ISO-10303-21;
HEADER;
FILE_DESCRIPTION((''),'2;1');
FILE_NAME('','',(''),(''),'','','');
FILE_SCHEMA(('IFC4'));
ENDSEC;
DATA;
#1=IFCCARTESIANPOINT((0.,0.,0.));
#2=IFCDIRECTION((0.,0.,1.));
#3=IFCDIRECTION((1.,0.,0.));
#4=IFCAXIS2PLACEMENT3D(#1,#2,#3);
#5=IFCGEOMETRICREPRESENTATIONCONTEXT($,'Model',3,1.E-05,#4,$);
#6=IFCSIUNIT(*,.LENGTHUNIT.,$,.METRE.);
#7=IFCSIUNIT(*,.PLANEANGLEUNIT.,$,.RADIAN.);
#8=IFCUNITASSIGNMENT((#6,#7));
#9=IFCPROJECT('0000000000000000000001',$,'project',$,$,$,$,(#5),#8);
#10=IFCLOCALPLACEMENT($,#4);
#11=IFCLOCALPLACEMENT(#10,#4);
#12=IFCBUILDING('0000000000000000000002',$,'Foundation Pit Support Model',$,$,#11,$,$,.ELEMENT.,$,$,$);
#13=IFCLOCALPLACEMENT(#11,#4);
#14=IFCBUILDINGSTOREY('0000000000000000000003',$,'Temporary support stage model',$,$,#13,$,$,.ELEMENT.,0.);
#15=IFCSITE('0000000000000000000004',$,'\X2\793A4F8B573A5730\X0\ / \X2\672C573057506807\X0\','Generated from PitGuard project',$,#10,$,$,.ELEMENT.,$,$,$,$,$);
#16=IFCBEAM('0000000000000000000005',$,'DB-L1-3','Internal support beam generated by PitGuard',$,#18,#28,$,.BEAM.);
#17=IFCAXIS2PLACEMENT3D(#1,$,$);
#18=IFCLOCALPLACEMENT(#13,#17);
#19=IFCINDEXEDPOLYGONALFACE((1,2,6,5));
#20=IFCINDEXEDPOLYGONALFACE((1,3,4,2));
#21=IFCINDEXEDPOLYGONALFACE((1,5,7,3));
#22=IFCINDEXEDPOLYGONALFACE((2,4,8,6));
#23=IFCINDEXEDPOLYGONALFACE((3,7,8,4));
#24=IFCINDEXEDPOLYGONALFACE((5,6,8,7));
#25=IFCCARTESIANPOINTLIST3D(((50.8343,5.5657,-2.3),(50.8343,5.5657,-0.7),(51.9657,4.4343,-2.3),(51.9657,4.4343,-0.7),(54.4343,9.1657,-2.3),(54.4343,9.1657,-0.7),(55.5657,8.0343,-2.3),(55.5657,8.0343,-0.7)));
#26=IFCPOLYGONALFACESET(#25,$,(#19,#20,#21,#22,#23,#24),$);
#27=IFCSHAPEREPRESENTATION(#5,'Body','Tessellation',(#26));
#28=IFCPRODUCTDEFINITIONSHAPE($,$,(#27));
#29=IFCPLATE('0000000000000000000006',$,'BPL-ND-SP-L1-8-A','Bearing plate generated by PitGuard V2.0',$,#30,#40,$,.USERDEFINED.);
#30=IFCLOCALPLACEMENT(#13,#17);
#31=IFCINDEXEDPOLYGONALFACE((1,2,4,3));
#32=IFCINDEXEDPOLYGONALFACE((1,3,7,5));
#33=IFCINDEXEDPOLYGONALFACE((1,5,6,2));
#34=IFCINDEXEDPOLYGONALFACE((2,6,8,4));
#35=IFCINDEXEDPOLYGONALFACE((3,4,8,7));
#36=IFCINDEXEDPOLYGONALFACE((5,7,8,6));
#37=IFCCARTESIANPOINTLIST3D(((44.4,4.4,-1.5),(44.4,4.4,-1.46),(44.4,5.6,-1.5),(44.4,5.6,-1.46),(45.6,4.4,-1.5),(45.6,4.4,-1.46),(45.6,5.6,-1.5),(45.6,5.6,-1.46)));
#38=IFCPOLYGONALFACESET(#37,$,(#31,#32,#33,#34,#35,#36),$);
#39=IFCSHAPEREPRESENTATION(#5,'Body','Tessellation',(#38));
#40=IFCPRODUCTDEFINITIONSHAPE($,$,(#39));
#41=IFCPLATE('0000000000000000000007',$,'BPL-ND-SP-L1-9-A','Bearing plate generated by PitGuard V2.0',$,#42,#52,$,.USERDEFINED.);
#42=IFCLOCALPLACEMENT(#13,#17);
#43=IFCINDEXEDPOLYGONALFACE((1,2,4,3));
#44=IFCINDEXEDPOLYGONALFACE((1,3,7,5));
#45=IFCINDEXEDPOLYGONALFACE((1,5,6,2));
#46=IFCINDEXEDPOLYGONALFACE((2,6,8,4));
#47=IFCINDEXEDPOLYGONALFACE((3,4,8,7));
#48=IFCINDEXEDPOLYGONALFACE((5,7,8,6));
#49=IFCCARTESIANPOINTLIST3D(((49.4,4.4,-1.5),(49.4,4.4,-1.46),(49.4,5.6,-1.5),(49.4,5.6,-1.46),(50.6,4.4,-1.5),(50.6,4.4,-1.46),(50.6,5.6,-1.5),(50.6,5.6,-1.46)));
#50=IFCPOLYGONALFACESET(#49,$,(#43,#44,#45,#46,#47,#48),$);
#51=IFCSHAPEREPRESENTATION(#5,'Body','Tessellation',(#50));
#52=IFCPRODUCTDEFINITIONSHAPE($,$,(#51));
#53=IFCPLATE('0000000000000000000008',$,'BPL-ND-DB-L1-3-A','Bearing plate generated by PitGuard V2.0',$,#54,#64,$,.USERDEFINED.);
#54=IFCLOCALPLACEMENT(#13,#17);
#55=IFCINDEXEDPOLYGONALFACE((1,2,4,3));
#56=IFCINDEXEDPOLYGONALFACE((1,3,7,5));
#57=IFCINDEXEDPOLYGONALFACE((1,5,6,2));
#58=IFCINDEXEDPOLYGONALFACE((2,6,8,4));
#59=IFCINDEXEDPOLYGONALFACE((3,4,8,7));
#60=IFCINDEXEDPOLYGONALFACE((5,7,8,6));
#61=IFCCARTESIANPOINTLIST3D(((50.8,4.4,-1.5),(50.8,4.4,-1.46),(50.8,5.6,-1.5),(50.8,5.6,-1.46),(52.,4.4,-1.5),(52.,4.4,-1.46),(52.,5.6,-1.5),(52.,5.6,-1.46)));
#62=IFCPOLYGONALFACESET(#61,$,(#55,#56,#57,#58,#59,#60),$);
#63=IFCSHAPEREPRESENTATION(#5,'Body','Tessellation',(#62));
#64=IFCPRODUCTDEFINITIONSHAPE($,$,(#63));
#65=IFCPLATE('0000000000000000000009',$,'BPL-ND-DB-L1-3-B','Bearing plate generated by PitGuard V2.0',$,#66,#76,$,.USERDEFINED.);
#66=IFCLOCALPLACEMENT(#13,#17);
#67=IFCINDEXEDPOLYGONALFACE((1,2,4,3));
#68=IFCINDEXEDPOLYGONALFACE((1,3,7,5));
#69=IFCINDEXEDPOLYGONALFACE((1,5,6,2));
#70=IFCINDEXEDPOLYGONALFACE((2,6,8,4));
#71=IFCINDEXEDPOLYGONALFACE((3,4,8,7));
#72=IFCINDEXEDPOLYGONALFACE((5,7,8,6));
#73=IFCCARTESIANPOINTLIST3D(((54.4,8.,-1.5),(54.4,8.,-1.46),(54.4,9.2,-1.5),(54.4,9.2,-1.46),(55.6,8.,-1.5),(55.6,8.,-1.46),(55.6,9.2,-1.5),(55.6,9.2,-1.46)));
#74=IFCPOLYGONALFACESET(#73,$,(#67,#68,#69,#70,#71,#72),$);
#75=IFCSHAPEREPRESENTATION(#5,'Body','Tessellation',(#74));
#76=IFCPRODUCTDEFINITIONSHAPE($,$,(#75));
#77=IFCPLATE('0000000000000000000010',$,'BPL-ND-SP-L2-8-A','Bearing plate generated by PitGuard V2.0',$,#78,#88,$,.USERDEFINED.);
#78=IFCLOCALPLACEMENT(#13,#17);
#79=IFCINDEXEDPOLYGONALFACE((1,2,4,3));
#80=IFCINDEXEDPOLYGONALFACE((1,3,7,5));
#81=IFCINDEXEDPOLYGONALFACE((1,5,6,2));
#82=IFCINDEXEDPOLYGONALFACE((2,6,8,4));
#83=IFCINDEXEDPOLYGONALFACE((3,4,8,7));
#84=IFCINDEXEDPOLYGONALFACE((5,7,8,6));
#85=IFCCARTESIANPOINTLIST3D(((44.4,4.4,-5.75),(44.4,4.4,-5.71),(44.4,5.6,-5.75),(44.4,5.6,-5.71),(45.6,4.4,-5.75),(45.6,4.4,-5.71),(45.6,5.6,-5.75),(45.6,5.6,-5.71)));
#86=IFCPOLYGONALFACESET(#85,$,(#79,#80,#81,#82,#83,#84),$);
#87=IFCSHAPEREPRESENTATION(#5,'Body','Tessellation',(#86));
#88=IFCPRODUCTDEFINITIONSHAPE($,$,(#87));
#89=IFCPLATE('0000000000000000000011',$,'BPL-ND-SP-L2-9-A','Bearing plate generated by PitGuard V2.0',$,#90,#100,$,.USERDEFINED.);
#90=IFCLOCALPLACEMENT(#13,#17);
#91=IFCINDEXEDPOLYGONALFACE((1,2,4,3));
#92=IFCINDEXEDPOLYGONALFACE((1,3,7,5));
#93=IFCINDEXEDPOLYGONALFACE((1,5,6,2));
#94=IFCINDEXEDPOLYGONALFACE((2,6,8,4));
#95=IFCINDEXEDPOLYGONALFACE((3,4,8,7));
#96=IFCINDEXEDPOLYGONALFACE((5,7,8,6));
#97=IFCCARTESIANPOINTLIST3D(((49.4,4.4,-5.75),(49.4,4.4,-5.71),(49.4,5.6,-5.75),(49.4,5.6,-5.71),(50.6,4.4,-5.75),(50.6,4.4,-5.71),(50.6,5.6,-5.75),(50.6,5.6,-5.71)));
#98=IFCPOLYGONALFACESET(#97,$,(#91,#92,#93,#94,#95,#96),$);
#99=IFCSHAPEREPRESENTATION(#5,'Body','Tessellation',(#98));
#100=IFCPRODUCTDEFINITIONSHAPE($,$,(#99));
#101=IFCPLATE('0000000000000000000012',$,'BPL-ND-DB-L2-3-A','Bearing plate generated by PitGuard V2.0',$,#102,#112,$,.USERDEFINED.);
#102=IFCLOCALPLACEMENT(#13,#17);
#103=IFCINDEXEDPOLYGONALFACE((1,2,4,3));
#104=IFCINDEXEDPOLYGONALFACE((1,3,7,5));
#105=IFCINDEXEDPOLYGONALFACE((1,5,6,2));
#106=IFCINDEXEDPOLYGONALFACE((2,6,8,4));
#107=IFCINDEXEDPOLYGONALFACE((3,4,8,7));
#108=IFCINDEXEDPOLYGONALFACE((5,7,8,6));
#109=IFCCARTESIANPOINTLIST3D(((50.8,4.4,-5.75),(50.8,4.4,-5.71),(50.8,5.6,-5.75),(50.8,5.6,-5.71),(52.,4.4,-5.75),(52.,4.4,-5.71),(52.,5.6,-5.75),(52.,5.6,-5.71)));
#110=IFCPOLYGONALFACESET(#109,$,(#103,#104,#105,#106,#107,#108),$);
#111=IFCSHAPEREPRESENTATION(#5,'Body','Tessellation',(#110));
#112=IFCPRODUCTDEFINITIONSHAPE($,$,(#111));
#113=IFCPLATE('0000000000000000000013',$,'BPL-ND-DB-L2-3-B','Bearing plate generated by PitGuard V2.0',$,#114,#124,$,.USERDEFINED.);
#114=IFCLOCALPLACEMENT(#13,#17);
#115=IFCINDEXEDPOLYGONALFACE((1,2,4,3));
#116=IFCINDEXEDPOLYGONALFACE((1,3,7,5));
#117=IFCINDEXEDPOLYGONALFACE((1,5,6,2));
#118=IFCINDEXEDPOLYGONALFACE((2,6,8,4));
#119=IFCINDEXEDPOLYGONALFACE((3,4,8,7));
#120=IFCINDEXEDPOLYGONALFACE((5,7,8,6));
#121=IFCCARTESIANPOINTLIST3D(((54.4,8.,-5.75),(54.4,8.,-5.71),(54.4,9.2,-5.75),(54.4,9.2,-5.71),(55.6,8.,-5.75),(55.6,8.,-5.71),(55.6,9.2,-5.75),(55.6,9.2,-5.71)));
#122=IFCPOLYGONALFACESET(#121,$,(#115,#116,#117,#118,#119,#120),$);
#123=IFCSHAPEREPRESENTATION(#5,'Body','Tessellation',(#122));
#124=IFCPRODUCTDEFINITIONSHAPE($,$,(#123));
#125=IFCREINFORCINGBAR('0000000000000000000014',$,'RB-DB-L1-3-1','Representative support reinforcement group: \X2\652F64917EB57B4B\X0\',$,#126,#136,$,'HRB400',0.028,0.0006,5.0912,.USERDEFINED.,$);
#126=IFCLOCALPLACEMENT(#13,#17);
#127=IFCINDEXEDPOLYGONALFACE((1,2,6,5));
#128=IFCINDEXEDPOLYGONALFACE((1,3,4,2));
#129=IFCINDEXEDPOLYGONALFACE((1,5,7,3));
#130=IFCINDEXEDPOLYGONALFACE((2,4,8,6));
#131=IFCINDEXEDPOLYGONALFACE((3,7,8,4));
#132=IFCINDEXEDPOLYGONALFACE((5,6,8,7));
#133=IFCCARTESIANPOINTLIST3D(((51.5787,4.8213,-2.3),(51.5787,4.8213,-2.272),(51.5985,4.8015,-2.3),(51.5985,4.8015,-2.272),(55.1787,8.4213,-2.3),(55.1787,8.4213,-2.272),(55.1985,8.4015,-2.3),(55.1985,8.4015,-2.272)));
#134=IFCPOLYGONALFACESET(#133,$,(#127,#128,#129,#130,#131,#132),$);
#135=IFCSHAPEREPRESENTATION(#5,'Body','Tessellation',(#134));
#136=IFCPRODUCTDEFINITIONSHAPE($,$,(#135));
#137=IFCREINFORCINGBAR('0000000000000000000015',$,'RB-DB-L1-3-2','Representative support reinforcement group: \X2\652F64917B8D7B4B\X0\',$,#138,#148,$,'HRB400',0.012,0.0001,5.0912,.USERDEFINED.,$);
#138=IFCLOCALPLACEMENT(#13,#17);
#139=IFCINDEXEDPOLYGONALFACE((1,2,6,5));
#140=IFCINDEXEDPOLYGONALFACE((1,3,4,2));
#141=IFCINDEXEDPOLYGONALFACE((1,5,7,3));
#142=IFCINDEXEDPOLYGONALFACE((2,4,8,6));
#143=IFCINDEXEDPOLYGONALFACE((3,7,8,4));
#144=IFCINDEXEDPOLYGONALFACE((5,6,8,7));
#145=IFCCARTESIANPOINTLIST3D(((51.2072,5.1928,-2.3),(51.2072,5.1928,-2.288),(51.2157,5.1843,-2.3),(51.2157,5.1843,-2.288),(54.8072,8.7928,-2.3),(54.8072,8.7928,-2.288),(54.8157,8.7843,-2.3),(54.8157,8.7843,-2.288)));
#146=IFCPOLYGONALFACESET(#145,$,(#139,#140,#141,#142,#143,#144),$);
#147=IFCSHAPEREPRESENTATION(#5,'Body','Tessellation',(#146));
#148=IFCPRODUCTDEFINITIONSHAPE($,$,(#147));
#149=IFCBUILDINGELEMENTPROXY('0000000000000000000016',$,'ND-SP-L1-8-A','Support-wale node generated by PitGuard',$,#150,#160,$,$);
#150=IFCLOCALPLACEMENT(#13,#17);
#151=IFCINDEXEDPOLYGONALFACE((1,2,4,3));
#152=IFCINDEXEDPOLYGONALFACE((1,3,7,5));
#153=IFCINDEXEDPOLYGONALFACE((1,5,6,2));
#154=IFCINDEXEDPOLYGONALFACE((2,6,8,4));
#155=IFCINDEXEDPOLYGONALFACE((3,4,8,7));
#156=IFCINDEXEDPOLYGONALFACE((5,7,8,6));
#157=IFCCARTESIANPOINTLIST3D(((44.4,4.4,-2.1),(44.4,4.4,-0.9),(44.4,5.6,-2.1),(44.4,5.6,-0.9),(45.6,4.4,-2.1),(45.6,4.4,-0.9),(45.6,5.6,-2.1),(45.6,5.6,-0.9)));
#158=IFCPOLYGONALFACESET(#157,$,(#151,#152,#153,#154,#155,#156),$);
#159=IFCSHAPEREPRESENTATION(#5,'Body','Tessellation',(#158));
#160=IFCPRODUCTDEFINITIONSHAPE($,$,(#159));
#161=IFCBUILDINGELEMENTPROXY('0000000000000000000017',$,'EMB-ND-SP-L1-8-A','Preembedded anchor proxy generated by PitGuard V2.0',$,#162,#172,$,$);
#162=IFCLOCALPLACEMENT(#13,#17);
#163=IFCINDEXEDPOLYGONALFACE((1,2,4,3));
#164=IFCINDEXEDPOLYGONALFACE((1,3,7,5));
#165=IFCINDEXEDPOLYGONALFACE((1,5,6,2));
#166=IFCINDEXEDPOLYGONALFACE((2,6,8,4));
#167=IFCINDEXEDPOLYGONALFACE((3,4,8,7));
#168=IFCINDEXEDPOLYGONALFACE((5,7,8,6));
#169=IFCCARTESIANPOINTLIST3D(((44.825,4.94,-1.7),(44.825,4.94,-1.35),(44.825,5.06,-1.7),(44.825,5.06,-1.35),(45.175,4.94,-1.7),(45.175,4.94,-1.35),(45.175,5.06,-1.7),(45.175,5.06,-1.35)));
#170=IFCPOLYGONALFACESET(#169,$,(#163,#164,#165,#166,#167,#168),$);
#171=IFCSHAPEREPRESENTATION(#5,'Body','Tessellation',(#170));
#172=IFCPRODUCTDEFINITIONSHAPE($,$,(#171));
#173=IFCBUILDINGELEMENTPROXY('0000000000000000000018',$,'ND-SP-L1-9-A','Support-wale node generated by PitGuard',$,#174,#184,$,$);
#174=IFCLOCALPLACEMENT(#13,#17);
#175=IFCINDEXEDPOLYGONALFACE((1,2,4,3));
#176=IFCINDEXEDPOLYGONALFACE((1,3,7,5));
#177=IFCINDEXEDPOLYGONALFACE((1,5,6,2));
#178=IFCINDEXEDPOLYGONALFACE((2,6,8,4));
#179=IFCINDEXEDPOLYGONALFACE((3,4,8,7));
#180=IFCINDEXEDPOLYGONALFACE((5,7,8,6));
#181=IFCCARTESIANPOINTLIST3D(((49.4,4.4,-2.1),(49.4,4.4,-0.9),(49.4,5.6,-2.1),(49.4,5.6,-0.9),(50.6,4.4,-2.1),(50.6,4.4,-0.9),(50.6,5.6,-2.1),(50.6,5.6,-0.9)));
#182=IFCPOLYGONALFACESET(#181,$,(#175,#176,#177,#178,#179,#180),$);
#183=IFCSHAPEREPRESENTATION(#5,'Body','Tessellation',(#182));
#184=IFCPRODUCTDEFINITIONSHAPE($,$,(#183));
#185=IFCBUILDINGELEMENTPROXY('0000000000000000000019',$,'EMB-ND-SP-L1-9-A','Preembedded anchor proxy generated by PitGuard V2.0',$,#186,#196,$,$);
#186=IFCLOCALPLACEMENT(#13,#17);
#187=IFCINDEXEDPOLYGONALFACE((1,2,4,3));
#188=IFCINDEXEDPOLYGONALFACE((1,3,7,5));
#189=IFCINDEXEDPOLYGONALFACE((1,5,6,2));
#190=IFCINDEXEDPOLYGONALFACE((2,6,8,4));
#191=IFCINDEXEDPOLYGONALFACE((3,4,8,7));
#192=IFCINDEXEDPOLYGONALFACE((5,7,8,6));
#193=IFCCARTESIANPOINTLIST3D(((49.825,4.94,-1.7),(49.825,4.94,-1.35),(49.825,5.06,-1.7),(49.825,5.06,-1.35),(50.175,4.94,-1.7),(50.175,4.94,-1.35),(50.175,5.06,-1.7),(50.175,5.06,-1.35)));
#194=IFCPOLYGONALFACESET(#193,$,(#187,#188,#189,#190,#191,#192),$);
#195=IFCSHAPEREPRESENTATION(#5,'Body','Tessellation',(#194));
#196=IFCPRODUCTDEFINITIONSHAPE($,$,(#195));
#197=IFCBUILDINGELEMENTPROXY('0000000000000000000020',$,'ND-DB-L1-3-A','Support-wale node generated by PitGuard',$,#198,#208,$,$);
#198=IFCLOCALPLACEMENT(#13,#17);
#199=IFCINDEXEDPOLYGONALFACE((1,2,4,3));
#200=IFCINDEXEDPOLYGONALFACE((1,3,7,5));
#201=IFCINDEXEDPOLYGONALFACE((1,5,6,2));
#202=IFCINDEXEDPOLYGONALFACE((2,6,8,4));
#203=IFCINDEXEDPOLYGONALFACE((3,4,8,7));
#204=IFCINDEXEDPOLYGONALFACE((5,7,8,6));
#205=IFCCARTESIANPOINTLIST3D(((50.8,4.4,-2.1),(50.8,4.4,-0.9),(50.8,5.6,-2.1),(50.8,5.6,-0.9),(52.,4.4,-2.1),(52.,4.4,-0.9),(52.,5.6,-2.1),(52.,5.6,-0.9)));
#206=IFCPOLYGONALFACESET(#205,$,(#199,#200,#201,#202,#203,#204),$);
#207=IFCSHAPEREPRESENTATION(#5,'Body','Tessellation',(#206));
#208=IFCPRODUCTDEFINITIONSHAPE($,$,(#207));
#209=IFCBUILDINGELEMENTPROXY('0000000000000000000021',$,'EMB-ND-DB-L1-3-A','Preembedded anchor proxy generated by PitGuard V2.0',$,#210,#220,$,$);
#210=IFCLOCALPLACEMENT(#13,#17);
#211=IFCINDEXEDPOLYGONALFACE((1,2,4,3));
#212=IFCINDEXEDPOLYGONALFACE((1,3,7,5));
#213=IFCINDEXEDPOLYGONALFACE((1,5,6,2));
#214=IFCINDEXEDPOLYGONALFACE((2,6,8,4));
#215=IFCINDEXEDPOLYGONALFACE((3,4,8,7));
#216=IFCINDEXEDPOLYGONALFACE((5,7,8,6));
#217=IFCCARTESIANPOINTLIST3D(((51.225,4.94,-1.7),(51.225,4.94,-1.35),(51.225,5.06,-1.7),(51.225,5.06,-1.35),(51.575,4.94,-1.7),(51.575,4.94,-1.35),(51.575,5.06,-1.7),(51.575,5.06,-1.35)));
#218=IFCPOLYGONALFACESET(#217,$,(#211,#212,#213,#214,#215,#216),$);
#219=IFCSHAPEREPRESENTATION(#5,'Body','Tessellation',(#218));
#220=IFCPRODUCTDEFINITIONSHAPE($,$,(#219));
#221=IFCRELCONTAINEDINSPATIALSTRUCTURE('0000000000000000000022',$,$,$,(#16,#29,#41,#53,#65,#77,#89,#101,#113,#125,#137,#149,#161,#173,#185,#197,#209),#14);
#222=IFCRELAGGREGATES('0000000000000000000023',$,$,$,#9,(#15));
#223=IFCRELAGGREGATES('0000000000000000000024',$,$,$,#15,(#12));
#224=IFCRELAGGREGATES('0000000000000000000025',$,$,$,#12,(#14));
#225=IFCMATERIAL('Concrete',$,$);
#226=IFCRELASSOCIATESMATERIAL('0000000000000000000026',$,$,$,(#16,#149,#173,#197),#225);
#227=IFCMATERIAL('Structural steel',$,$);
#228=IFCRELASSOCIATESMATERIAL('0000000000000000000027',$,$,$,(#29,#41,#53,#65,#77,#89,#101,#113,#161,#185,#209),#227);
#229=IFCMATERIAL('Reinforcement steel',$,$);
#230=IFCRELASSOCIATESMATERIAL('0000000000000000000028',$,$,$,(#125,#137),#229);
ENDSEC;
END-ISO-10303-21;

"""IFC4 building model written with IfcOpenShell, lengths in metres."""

from ifc_helpers import new_model, si_unit, frame, origin_with_axes, origin_2d, place, context, project, spatial, rectangle, extrude, material, element, save


model = new_model("IFC4")

# Units and contexts
model_context = context("Model", 3, precision=1e-05, world=origin_with_axes())
ifc_project = project(units=[si_unit("LENGTHUNIT", "METRE"), si_unit("PLANEANGLEUNIT", "RADIAN")], contexts=[model_context])

# Site, building, storey
site_placement = place(None, origin_with_axes())
site = spatial("IfcSite", under=ifc_project, at=site_placement, Name="示例场地 / 本地坐标", Description="Generated from PitGuard project", CompositionType="ELEMENT")
building_placement = place(site_placement, origin_with_axes())
building = spatial("IfcBuilding", under=site, at=building_placement, Name="Foundation Pit Support Model", CompositionType="ELEMENT")
storey_placement = place(building_placement, origin_with_axes())
storey = spatial("IfcBuildingStorey", under=building, at=storey_placement, Name="Temporary support stage model", CompositionType="ELEMENT", Elevation=0.0)

# Beam
ifc_material_1 = material(Name="Concrete")
beam_placement = place(storey_placement, frame((53.2, 6.8, -2.3), z_axis=(0.0, 0.0, 1.0), x_axis=(0.707107, 0.707107, 0.0)))
element("IfcBeam", 1, at=beam_placement, inside=storey, material=ifc_material_1, Name="DB-L1-3", Description="Internal support beam generated by PitGuard", PredefinedType="BEAM", context=model_context, shape_type="SweptSolid", body=[
    extrude(rectangle(XDim=5.0912, YDim=1.6, at=origin_2d()), origin_with_axes(), (0.0, 0.0, 1.0), 1.6),
])

# Plates
ifc_material_2 = material(Name="Structural steel")
for number, where, z_axis, x_axis, name in (
    (2, (45.0, 5.0, -1.5), (0.0, 0.0, 1.0), (1.0, 0.0, 0.0), "BPL-ND-SP-L1-8-A"),
    (3, (50.0, 5.0, -1.5), (0.0, 0.0, 1.0), (1.0, 0.0, 0.0), "BPL-ND-SP-L1-9-A"),
    (4, (51.4, 5.0, -1.5), (0.0, 0.0, 1.0), (1.0, 0.0, 0.0), "BPL-ND-DB-L1-3-A"),
    (5, (55.0, 8.6, -1.5), (0.0, 0.0, 1.0), (1.0, 0.0, 0.0), "BPL-ND-DB-L1-3-B"),
    (6, (45.0, 5.0, -5.75), (0.0, 0.0, 1.0), (1.0, 0.0, 0.0), "BPL-ND-SP-L2-8-A"),
    (7, (50.0, 5.0, -5.75), (0.0, 0.0, 1.0), (1.0, 0.0, 0.0), "BPL-ND-SP-L2-9-A"),
    (8, (51.4, 5.0, -5.75), (0.0, 0.0, 1.0), (1.0, 0.0, 0.0), "BPL-ND-DB-L2-3-A"),
    (9, (55.0, 8.6, -5.75), (0.0, 0.0, 1.0), (1.0, 0.0, 0.0), "BPL-ND-DB-L2-3-B"),
):
    element("IfcPlate", number, at=place(storey_placement, frame(where, z_axis=z_axis, x_axis=x_axis)), inside=storey, material=ifc_material_2, Name=name, Description="Bearing plate generated by PitGuard V2.0", PredefinedType="USERDEFINED", context=model_context, shape_type="SweptSolid", body=[
        extrude(rectangle(XDim=1.2, YDim=1.2, at=origin_2d()), origin_with_axes(), (0.0, 0.0, 1.0), 0.04),
    ])

# Reinforcing bars
ifc_material_3 = material(Name="Reinforcement steel")
reinforcing_bar_1_placement = place(storey_placement, frame((53.3886, 6.6114, -2.3), z_axis=(0.0, 0.0, 1.0), x_axis=(0.707107, 0.707107, 0.0)))
element("IfcReinforcingBar", 10, at=reinforcing_bar_1_placement, inside=storey, material=ifc_material_3, Name="RB-DB-L1-3-1", Description="Representative support reinforcement group: 支撑纵筋", SteelGrade="HRB400", BarLength=5.0912, CrossSectionArea=0.0006, NominalDiameter=0.028, PredefinedType="USERDEFINED", context=model_context, shape_type="SweptSolid", body=[
    extrude(rectangle(XDim=5.0912, YDim=0.028, at=origin_2d()), origin_with_axes(), (0.0, 0.0, 1.0), 0.028),
])
reinforcing_bar_2_placement = place(storey_placement, frame((53.0114, 6.9886, -2.3), z_axis=(0.0, 0.0, 1.0), x_axis=(0.707107, 0.707107, 0.0)))
element("IfcReinforcingBar", 11, at=reinforcing_bar_2_placement, inside=storey, material=ifc_material_3, Name="RB-DB-L1-3-2", Description="Representative support reinforcement group: 支撑箍筋", SteelGrade="HRB400", BarLength=5.0912, CrossSectionArea=0.0001, NominalDiameter=0.012, PredefinedType="USERDEFINED", context=model_context, shape_type="SweptSolid", body=[
    extrude(rectangle(XDim=5.0912, YDim=0.012, at=origin_2d()), origin_with_axes(), (0.0, 0.0, 1.0), 0.012),
])

# Building element proxies
proxy_1_placement = place(storey_placement, frame((45.0, 5.0, -2.1), z_axis=(0.0, 0.0, 1.0), x_axis=(1.0, 0.0, 0.0)))
element("IfcBuildingElementProxy", 12, at=proxy_1_placement, inside=storey, material=ifc_material_1, Name="ND-SP-L1-8-A", Description="Support-wale node generated by PitGuard", context=model_context, shape_type="SweptSolid", body=[
    extrude(rectangle(XDim=1.2, YDim=1.2, at=origin_2d()), origin_with_axes(), (0.0, 0.0, 1.0), 1.2),
])
proxy_2_placement = place(storey_placement, frame((45.0, 5.0, -1.7), z_axis=(0.0, 0.0, 1.0), x_axis=(1.0, 0.0, 0.0)))
element("IfcBuildingElementProxy", 13, at=proxy_2_placement, inside=storey, material=ifc_material_2, Name="EMB-ND-SP-L1-8-A", Description="Preembedded anchor proxy generated by PitGuard V2.0", context=model_context, shape_type="SweptSolid", body=[
    extrude(rectangle(XDim=0.35, YDim=0.12, at=origin_2d()), origin_with_axes(), (0.0, 0.0, 1.0), 0.35),
])
proxy_3_placement = place(storey_placement, frame((50.0, 5.0, -2.1), z_axis=(0.0, 0.0, 1.0), x_axis=(1.0, 0.0, 0.0)))
element("IfcBuildingElementProxy", 14, at=proxy_3_placement, inside=storey, material=ifc_material_1, Name="ND-SP-L1-9-A", Description="Support-wale node generated by PitGuard", context=model_context, shape_type="SweptSolid", body=[
    extrude(rectangle(XDim=1.2, YDim=1.2, at=origin_2d()), origin_with_axes(), (0.0, 0.0, 1.0), 1.2),
])
proxy_4_placement = place(storey_placement, frame((50.0, 5.0, -1.7), z_axis=(0.0, 0.0, 1.0), x_axis=(1.0, 0.0, 0.0)))
element("IfcBuildingElementProxy", 15, at=proxy_4_placement, inside=storey, material=ifc_material_2, Name="EMB-ND-SP-L1-9-A", Description="Preembedded anchor proxy generated by PitGuard V2.0", context=model_context, shape_type="SweptSolid", body=[
    extrude(rectangle(XDim=0.35, YDim=0.12, at=origin_2d()), origin_with_axes(), (0.0, 0.0, 1.0), 0.35),
])
proxy_5_placement = place(storey_placement, frame((51.4, 5.0, -2.1), z_axis=(0.0, 0.0, 1.0), x_axis=(1.0, 0.0, 0.0)))
element("IfcBuildingElementProxy", 16, at=proxy_5_placement, inside=storey, material=ifc_material_1, Name="ND-DB-L1-3-A", Description="Support-wale node generated by PitGuard", context=model_context, shape_type="SweptSolid", body=[
    extrude(rectangle(XDim=1.2, YDim=1.2, at=origin_2d()), origin_with_axes(), (0.0, 0.0, 1.0), 1.2),
])
proxy_6_placement = place(storey_placement, frame((51.4, 5.0, -1.7), z_axis=(0.0, 0.0, 1.0), x_axis=(1.0, 0.0, 0.0)))
element("IfcBuildingElementProxy", 17, at=proxy_6_placement, inside=storey, material=ifc_material_2, Name="EMB-ND-DB-L1-3-A", Description="Preembedded anchor proxy generated by PitGuard V2.0", context=model_context, shape_type="SweptSolid", body=[
    extrude(rectangle(XDim=0.35, YDim=0.12, at=origin_2d()), origin_with_axes(), (0.0, 0.0, 1.0), 0.35),
])

save(model, "model.ifc")
